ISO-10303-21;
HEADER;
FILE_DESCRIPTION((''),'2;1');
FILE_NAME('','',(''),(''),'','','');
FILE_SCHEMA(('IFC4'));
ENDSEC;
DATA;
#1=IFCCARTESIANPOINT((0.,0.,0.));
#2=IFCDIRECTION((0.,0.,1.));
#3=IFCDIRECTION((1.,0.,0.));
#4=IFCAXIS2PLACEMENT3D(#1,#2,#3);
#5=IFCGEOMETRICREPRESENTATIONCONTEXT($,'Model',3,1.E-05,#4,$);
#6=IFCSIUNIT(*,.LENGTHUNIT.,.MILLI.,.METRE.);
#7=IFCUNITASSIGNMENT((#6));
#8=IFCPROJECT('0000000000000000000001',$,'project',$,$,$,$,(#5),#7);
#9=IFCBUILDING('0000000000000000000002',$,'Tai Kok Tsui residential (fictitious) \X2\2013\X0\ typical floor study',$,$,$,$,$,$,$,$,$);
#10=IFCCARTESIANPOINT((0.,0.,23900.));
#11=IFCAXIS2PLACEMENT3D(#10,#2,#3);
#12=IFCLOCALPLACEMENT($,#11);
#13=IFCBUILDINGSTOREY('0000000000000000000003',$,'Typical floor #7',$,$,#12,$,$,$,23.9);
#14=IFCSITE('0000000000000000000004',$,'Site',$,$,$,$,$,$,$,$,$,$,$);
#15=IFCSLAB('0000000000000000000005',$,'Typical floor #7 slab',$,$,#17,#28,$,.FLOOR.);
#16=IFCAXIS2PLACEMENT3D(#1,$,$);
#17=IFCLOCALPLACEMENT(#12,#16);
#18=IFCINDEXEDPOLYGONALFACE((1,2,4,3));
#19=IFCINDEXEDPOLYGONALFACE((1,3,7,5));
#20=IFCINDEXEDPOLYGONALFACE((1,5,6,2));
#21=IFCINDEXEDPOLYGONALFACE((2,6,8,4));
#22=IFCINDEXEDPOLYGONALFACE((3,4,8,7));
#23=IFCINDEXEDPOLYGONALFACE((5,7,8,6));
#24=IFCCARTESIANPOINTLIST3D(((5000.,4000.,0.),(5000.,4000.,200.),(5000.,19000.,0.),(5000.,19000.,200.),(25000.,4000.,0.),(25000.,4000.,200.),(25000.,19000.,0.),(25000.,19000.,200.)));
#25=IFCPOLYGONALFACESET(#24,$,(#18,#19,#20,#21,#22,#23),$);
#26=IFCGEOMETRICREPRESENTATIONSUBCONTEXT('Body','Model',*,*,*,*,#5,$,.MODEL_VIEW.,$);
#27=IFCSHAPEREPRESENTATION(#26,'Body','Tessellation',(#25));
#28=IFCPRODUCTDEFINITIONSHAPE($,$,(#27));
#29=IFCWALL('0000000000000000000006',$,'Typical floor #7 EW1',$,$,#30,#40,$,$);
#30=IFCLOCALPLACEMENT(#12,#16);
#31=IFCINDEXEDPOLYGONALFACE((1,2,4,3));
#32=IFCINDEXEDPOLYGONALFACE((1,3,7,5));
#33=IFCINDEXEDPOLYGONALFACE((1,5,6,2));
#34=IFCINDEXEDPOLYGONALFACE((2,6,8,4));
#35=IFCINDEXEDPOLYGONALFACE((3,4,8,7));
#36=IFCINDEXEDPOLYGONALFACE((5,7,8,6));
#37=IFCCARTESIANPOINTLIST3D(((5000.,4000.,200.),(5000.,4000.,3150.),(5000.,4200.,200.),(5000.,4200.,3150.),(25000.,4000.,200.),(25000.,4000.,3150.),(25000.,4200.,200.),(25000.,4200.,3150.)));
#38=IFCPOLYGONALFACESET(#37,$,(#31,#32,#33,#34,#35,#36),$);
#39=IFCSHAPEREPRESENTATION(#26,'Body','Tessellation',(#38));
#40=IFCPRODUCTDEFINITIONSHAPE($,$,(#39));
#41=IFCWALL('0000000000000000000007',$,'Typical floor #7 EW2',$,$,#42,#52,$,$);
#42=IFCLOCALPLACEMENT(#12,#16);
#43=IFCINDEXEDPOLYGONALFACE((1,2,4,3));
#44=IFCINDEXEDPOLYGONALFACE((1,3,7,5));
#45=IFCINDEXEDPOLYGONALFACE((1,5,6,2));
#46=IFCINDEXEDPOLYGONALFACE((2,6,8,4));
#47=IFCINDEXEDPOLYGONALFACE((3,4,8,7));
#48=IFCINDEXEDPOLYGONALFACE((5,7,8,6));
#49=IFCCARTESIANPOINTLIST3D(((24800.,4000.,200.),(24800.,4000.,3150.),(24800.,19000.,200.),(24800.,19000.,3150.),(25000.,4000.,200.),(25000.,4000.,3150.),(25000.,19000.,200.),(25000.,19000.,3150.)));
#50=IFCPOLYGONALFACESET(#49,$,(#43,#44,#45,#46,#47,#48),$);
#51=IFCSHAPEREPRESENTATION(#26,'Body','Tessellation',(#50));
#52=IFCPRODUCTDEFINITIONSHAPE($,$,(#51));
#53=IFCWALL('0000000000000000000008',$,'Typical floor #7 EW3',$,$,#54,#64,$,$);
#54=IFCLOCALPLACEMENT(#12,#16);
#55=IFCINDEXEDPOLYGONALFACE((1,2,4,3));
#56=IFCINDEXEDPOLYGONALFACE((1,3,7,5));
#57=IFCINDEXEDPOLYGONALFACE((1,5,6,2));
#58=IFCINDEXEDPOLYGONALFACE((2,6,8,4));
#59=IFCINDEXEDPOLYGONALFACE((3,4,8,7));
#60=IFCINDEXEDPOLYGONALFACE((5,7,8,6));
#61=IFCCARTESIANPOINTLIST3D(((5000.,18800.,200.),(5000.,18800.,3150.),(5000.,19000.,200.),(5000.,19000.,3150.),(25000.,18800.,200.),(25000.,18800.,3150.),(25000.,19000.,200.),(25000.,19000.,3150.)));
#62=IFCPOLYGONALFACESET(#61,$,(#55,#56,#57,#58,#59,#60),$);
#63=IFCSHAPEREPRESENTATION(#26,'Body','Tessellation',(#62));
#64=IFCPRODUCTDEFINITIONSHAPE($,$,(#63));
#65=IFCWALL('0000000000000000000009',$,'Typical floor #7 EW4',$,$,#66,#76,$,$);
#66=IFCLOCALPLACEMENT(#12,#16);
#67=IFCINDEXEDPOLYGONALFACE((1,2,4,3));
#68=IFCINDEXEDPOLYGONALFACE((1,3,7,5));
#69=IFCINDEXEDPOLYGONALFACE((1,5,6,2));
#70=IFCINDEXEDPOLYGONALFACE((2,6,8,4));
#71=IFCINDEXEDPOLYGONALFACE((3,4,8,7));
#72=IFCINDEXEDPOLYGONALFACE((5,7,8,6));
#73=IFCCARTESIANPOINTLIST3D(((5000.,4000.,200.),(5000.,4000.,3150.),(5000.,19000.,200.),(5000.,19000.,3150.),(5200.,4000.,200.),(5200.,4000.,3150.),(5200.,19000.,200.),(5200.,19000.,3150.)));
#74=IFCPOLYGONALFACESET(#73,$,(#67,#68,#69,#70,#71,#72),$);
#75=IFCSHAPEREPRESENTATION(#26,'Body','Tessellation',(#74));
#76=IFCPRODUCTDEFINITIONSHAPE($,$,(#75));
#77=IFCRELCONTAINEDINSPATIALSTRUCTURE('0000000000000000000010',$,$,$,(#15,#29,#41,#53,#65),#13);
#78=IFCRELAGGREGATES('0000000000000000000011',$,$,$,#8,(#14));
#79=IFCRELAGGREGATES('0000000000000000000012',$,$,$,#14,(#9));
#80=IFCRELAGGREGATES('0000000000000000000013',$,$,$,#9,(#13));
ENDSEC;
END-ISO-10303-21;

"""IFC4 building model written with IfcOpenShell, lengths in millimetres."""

from ifc_helpers import new_model, si_unit, frame, origin_with_axes, place, context, subcontext, project, spatial, indexed_curve, outline, extrude, element, save


model = new_model("IFC4")

# Units and contexts
model_context = context("Model", 3, precision=1e-05, world=origin_with_axes())
body_context = subcontext(model_context, "Body", "Model", "MODEL_VIEW")
ifc_project = project(units=[si_unit("LENGTHUNIT", "METRE", prefix="MILLI")], contexts=[model_context])

# Site, building, storey
site = spatial("IfcSite", under=ifc_project, Name="Site")
building = spatial("IfcBuilding", under=site, Name="Tai Kok Tsui residential (fictitious) – typical floor study")
storey_placement = place(None, frame((0.0, 0.0, 23900.0), z_axis=(0.0, 0.0, 1.0), x_axis=(1.0, 0.0, 0.0)))
storey = spatial("IfcBuildingStorey", under=building, at=storey_placement, Name="Typical floor #7", Elevation=23.9)

# Slab
slab_placement = place(storey_placement, origin_with_axes())
element("IfcSlab", 1, at=slab_placement, inside=storey, Name="Typical floor #7 slab", PredefinedType="FLOOR", context=body_context, shape_type="SweptSolid", body=[
    extrude(outline(indexed_curve([(5000.0, 4000.0), (25000.0, 4000.0), (25000.0, 19000.0), (5000.0, 19000.0)])), None, (0.0, 0.0, 1.0), 200.0),
])

# Walls
wall_1_placement = place(storey_placement, frame((5000.0, 4000.0, 200.0), z_axis=(0.0, 0.0, 1.0), x_axis=(1.0, 0.0, 0.0)))
element("IfcWall", 2, at=wall_1_placement, inside=storey, Name="Typical floor #7 EW1", context=body_context, shape_type="SweptSolid", body=[
    extrude(outline(indexed_curve([(0.0, 0.0), (0.0, 200.0), (20000.0, 200.0), (20000.0, 0.0), (0.0, 0.0)], self_intersect=False)), origin_with_axes(), (0.0, 0.0, 1.0), 2950.0),
])
wall_2_placement = place(storey_placement, frame((25000.0, 4000.0, 200.0), z_axis=(0.0, 0.0, 1.0), x_axis=(0.0, 1.0, 0.0)))
element("IfcWall", 3, at=wall_2_placement, inside=storey, Name="Typical floor #7 EW2", context=body_context, shape_type="SweptSolid", body=[
    extrude(outline(indexed_curve([(0.0, 0.0), (0.0, 200.0), (15000.0, 200.0), (15000.0, 0.0), (0.0, 0.0)], self_intersect=False)), origin_with_axes(), (0.0, 0.0, 1.0), 2950.0),
])
wall_3_placement = place(storey_placement, frame((25000.0, 19000.0, 200.0), z_axis=(0.0, 0.0, 1.0), x_axis=(-1.0, 0.0, 0.0)))
element("IfcWall", 4, at=wall_3_placement, inside=storey, Name="Typical floor #7 EW3", context=body_context, shape_type="SweptSolid", body=[
    extrude(outline(indexed_curve([(0.0, 0.0), (0.0, 200.0), (20000.0, 200.0), (20000.0, 0.0), (0.0, 0.0)], self_intersect=False)), origin_with_axes(), (0.0, 0.0, 1.0), 2950.0),
])
wall_4_placement = place(storey_placement, frame((5000.0, 19000.0, 200.0), z_axis=(0.0, 0.0, 1.0), x_axis=(0.0, -1.0, 0.0)))
element("IfcWall", 5, at=wall_4_placement, inside=storey, Name="Typical floor #7 EW4", context=body_context, shape_type="SweptSolid", body=[
    extrude(outline(indexed_curve([(0.0, 0.0), (0.0, 200.0), (15000.0, 200.0), (15000.0, 0.0), (0.0, 0.0)], self_intersect=False)), origin_with_axes(), (0.0, 0.0, 1.0), 2950.0),
])

save(model, "model.ifc")
